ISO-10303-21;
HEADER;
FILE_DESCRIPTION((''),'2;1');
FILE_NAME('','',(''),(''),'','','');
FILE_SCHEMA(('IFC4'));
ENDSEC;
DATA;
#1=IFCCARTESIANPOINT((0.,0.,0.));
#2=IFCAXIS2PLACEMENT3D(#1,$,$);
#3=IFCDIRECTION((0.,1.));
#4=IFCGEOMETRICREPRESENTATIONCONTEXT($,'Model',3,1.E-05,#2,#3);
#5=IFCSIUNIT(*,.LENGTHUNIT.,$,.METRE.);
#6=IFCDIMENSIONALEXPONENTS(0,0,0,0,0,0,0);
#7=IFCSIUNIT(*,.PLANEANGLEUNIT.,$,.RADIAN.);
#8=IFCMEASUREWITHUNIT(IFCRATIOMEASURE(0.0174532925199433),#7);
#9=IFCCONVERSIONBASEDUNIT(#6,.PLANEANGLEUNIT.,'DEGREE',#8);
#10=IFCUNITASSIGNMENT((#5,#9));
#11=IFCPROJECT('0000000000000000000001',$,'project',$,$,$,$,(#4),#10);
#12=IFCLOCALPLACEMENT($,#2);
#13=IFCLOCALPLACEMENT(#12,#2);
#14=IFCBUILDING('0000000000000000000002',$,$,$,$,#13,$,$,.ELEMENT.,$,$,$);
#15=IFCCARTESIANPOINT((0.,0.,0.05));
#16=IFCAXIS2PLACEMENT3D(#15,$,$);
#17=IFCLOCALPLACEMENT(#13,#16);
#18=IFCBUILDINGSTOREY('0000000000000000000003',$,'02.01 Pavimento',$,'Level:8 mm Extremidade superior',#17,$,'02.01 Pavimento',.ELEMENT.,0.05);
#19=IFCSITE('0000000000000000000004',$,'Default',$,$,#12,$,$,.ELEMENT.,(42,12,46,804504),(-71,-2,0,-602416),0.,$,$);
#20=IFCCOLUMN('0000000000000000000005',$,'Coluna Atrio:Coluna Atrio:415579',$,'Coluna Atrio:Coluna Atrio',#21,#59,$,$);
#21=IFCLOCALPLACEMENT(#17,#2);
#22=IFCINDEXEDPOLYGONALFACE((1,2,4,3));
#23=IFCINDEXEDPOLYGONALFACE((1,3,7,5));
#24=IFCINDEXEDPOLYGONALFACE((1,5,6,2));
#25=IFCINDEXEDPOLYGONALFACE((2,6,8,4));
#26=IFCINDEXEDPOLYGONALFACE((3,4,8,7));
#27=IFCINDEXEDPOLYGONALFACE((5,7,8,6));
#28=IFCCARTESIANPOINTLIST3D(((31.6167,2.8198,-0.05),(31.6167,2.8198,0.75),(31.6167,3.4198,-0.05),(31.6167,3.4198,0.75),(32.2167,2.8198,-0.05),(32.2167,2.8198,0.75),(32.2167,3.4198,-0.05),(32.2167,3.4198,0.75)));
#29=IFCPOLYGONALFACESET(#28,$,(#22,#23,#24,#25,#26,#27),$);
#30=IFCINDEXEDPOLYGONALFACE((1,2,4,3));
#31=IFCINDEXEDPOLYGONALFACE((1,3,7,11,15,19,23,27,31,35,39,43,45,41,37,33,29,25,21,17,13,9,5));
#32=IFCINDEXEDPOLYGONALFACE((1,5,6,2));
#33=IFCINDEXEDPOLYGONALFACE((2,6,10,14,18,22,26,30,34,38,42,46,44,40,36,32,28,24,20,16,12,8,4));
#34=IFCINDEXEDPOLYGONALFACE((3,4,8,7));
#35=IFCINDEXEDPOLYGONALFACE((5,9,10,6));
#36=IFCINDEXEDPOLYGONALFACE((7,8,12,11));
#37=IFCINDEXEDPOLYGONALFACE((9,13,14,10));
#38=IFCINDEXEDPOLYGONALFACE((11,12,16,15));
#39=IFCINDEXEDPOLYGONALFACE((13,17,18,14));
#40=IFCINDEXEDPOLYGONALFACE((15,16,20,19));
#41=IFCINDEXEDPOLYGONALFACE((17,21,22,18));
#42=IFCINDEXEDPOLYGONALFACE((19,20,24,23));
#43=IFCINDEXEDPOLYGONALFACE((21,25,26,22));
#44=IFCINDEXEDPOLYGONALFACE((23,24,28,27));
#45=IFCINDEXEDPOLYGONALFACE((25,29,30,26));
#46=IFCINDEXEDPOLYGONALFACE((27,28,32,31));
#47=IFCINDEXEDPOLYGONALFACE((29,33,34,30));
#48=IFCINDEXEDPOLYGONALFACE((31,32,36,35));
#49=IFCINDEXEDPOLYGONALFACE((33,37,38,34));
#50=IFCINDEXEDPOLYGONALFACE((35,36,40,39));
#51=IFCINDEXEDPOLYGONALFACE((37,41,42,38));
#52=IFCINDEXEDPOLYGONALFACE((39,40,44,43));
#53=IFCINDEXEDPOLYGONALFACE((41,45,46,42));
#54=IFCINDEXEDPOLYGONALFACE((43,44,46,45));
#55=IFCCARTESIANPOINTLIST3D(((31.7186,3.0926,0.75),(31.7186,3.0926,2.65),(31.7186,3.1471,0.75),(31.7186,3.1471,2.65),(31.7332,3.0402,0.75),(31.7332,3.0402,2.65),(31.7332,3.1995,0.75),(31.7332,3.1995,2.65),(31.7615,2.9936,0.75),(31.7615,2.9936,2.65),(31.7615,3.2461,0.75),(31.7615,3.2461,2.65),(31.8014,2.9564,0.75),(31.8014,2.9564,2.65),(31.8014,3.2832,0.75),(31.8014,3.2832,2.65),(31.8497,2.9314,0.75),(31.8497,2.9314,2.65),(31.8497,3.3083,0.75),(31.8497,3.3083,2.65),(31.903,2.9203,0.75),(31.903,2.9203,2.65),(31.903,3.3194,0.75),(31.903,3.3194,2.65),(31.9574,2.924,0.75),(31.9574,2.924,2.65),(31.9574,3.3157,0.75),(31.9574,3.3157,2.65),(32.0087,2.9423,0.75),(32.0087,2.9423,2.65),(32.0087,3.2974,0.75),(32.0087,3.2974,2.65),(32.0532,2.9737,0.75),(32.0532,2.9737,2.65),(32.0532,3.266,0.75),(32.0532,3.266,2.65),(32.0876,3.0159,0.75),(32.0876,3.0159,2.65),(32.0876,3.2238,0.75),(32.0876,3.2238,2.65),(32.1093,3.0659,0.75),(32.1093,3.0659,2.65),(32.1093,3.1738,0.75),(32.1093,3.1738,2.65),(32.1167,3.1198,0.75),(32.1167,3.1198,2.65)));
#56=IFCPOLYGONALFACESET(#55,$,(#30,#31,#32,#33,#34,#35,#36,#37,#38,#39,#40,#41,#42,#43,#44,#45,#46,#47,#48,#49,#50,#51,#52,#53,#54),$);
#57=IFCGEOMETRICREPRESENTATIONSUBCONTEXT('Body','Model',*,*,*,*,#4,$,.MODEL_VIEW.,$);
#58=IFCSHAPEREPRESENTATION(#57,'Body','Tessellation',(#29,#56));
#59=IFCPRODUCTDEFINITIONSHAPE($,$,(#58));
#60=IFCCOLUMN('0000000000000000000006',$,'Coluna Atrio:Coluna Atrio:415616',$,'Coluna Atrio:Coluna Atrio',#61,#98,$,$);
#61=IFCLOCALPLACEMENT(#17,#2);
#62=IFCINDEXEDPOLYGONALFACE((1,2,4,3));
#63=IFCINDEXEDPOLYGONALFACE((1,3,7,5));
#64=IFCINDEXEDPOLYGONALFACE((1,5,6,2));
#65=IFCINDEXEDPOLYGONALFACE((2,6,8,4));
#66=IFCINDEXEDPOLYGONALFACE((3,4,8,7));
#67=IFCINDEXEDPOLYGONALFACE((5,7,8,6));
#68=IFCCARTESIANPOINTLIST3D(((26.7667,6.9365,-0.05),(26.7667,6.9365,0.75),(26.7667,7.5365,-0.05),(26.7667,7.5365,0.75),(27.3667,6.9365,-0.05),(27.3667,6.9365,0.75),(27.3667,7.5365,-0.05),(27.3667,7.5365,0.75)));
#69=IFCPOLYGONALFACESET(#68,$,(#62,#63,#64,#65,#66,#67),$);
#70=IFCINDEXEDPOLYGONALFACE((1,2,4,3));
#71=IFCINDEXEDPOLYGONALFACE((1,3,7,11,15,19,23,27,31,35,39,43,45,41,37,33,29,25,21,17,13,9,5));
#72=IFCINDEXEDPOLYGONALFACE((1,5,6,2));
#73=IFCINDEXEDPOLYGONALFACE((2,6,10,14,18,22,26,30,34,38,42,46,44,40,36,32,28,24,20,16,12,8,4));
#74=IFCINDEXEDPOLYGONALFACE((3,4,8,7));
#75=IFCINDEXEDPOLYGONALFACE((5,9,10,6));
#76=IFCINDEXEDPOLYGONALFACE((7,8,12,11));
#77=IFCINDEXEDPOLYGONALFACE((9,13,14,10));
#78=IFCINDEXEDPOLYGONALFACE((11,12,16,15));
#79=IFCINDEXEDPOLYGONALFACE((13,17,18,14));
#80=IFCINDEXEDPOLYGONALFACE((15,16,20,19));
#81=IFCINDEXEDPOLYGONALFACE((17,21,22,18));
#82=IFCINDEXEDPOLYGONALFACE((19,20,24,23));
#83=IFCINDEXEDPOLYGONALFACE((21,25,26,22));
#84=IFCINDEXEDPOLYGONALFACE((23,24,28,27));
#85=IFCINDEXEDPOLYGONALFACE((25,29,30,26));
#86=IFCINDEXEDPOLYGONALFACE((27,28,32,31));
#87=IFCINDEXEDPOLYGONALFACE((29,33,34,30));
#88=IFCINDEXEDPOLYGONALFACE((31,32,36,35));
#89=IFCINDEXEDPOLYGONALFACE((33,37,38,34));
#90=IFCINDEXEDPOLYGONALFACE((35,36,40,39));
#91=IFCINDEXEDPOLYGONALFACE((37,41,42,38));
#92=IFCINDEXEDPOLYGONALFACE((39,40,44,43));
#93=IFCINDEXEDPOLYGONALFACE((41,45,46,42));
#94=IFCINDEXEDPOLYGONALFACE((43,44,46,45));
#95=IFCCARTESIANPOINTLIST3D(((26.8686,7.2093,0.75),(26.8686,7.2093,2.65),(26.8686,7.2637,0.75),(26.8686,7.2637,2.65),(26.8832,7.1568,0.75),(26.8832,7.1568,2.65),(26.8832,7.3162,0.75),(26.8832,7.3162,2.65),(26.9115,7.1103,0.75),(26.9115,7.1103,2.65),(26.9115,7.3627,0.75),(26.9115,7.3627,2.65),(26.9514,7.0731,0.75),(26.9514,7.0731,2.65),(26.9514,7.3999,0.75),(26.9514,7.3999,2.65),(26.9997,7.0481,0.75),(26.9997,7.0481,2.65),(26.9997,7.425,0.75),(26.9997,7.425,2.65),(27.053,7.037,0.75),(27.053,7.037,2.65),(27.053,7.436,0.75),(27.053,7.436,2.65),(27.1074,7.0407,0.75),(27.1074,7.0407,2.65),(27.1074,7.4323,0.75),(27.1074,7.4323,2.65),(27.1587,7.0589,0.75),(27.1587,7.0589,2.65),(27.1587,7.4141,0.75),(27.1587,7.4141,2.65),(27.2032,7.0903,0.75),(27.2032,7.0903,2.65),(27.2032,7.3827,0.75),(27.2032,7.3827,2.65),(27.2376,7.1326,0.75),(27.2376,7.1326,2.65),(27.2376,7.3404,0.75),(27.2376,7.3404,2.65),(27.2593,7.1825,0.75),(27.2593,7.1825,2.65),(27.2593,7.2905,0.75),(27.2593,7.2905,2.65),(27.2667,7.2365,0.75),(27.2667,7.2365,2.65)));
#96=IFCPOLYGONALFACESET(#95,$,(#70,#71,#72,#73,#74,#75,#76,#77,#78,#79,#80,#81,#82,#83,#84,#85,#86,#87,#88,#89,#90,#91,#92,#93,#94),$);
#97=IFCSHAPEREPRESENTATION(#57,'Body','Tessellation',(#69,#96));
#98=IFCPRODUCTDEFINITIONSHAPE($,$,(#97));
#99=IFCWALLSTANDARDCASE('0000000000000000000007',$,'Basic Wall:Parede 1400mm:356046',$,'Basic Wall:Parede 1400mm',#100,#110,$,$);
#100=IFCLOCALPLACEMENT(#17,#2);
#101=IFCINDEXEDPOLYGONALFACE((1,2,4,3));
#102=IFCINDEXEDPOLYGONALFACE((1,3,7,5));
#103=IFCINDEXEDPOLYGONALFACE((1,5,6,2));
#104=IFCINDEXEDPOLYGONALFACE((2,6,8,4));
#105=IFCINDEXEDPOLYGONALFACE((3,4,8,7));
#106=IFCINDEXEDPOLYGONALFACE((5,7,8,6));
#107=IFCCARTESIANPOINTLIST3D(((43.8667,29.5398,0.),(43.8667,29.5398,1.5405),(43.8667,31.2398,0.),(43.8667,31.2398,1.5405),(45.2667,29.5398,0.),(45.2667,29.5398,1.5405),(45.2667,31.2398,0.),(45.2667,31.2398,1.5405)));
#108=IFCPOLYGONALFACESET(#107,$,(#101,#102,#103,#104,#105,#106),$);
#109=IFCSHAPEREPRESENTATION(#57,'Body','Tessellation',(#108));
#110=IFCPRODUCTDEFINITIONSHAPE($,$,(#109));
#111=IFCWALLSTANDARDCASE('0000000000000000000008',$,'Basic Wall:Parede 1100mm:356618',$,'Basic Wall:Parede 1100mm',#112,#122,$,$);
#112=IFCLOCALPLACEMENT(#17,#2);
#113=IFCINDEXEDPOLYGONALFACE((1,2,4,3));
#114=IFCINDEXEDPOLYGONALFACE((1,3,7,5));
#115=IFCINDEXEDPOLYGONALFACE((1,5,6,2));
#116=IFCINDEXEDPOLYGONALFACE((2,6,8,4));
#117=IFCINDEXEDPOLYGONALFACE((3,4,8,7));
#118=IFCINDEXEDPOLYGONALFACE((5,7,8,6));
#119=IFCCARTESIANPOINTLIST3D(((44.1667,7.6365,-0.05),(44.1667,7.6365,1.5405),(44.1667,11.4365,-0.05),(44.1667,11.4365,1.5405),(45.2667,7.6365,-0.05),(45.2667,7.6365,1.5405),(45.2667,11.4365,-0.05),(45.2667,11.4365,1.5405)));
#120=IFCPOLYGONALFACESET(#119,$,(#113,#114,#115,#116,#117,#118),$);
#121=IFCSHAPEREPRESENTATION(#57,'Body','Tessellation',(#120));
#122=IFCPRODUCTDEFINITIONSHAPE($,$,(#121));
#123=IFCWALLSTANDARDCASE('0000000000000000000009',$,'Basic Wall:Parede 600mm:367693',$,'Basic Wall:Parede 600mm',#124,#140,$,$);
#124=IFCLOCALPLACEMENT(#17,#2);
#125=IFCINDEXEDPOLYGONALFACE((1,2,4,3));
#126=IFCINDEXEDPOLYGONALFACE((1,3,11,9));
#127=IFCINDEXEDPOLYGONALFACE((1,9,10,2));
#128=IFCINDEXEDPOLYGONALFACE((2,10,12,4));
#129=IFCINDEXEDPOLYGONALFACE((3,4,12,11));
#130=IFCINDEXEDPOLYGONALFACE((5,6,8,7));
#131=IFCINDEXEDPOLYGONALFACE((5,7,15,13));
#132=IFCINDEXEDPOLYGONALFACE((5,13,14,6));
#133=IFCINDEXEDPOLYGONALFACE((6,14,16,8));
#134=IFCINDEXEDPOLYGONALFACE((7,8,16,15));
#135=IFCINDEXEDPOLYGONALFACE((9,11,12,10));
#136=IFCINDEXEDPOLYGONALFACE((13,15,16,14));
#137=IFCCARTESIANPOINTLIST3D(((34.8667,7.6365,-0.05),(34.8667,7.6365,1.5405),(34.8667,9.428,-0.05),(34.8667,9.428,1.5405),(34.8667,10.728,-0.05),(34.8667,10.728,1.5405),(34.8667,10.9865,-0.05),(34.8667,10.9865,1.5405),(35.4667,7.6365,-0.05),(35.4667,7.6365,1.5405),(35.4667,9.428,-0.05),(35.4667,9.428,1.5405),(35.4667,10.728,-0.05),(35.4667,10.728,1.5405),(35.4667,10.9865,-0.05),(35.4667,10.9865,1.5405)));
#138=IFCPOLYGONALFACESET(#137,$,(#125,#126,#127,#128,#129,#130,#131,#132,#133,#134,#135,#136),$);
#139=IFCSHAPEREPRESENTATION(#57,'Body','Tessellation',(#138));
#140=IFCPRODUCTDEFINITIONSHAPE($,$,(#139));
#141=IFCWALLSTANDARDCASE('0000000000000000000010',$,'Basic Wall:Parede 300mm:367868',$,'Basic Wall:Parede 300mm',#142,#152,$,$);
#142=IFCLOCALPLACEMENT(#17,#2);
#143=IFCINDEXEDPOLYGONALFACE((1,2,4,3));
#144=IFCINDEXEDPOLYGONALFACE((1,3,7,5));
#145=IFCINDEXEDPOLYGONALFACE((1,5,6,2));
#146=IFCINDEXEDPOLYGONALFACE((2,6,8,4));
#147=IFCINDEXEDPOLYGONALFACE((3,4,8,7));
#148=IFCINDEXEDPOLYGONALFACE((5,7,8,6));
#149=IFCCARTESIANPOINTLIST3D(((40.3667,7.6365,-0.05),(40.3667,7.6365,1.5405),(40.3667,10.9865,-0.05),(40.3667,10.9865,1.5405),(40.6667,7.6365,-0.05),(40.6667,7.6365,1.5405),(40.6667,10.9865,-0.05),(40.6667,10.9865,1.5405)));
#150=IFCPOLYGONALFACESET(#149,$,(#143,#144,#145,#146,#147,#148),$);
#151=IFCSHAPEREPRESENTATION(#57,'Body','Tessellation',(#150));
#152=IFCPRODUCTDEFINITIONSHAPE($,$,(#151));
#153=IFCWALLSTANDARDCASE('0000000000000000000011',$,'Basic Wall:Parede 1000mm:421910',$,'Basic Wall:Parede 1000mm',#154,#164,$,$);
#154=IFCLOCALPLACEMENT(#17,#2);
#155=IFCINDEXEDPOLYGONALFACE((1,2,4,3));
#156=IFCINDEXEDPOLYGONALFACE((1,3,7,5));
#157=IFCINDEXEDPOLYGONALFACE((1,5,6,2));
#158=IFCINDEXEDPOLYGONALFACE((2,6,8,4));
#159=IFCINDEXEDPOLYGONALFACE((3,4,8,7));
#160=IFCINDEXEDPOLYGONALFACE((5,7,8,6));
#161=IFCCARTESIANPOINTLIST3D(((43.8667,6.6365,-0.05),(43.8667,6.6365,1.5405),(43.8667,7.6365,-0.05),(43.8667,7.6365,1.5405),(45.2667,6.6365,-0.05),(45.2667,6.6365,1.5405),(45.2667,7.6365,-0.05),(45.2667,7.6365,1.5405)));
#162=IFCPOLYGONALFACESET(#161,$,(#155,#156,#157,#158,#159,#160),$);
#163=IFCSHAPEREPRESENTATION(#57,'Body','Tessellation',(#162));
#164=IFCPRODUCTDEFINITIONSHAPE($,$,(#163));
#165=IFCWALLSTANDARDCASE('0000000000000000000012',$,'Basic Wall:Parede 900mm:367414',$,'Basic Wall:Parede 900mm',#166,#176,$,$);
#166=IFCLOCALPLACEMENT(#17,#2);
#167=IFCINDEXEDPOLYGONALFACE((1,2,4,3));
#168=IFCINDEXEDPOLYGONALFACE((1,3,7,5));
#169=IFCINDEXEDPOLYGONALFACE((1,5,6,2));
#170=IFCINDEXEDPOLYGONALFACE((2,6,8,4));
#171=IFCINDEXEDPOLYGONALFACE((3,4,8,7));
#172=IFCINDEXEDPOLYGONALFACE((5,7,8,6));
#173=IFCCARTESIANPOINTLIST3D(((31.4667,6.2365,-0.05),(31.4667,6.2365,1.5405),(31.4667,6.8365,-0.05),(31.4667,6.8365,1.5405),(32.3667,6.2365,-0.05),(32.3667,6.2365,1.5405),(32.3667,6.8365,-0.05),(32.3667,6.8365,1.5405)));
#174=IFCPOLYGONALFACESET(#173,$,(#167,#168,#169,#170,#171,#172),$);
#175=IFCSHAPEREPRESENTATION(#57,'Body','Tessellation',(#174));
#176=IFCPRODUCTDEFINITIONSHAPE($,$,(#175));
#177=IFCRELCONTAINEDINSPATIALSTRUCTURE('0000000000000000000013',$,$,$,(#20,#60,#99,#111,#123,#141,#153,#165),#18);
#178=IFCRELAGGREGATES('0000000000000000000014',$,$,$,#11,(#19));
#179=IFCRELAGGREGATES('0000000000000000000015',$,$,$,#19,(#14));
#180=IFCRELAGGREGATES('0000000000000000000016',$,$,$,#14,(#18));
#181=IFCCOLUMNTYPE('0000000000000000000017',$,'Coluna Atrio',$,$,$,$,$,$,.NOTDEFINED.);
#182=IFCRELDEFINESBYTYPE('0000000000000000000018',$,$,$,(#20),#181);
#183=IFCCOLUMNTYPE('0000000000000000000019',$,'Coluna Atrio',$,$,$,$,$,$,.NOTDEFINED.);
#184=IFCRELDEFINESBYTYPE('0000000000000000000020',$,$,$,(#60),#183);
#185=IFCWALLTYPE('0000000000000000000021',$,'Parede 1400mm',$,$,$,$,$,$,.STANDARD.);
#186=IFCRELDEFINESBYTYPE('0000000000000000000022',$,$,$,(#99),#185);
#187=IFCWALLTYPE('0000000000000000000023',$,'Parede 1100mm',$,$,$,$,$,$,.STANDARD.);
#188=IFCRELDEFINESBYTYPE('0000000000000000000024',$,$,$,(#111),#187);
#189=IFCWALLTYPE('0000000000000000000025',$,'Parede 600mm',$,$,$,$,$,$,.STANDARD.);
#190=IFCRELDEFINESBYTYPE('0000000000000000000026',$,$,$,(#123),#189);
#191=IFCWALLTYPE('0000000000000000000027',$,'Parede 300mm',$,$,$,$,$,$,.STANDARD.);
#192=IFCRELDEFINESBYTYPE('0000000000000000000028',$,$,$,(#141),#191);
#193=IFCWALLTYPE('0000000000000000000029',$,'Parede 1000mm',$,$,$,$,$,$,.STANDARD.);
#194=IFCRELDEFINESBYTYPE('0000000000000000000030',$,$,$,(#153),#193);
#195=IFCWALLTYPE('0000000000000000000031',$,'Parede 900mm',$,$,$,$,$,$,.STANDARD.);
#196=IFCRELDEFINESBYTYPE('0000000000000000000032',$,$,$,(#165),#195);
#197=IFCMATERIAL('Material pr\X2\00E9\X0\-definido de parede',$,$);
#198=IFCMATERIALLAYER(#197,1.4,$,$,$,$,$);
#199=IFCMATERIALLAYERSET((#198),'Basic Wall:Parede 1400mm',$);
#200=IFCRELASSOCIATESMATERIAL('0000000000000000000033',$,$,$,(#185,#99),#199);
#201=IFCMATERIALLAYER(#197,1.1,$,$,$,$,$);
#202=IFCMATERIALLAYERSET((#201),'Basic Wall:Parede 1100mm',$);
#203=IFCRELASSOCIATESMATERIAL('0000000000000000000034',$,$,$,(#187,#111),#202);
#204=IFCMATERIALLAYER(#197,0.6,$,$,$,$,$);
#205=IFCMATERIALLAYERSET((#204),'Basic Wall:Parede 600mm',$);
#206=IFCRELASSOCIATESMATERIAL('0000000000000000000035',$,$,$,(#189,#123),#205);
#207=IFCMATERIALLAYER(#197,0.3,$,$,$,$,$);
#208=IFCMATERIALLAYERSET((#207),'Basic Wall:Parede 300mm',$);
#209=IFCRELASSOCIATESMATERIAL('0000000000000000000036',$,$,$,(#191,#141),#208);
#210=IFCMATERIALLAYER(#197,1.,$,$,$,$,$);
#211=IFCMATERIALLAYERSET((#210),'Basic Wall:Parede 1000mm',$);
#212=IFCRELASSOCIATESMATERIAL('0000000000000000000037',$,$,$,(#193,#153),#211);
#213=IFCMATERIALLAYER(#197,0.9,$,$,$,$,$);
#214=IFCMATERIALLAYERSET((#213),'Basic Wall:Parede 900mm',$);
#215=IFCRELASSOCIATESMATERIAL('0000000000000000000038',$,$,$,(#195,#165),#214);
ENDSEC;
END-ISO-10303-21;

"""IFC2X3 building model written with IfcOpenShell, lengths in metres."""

from ifc_helpers import new_model, entity, si_unit, converted_unit, direction, frame, frame_2d, origin, origin_2d_with_axis, place, context, subcontext, project, spatial, rectangle, circle, extrude, clip, halfspace, source, transform, mapped, material, layer, layer_set, layer_usage, type_object, type_shapes, element, save


model = new_model("IFC2X3")

# Units and contexts
model_context = context("Model", 3, precision=1e-05, world=origin(), true_north=direction((0.0, 1.0)))
body_context = subcontext(model_context, "Body", "Model", "MODEL_VIEW")
ifc_project = project(units=[si_unit("LENGTHUNIT", "METRE"), converted_unit("PLANEANGLEUNIT", "DEGREE", entity("IfcRatioMeasure", 0.0174532925199433), si_unit("PLANEANGLEUNIT", "RADIAN"), dimensions=[0, 0, 0, 0, 0, 0, 0])], contexts=[model_context])

# Site, building, storey
site_placement = place(None, origin())
site = spatial("IfcSite", under=ifc_project, at=site_placement, Name="Default", CompositionType="ELEMENT", RefLatitude=(42, 12, 46, 804504), RefLongitude=(-71, -2, 0, -602416), RefElevation=0.0)
building_placement = place(site_placement, origin())
building = spatial("IfcBuilding", under=site, at=building_placement, CompositionType="ELEMENT")
storey_placement = place(building_placement, frame((0.0, 0.0, 0.05)))
storey = spatial("IfcBuildingStorey", under=building, at=storey_placement, Name="02.01 Pavimento", ObjectType="Level:8 mm Extremidade superior", LongName="02.01 Pavimento", CompositionType="ELEMENT", Elevation=0.05)

# Columns
column_type_1 = type_object("IfcColumnType", Name="Coluna Atrio", PredefinedType="NOTDEFINED")
shared_shape_1 = source(origin(), body_context, "Body", "SweptSolid", [
    extrude(rectangle(XDim=0.6, YDim=0.6, at=origin_2d_with_axis()), frame((0.0, 0.0, 0.0), z_axis=(0.0, 0.0, 1.0), x_axis=(0.0, -1.0, 0.0)), (0.0, 0.0, 1.0), 0.8),
    extrude(circle(Radius=0.2, at=frame_2d((0.0, 0.0), x_axis=(1.0, 0.0))), frame((0.0, 0.0, 0.8)), (0.0, 0.0, 1.0), 1.9),
])
type_shapes(column_type_1, [shared_shape_1])
column_1_placement = place(storey_placement, frame((31.9167, 3.1198, -0.05)))
element("IfcColumn", 1, at=column_1_placement, inside=storey, type_object=column_type_1, Name="Coluna Atrio:Coluna Atrio:415579", ObjectType="Coluna Atrio:Coluna Atrio", context=body_context, shape_type="MappedRepresentation", body=[
    mapped(shared_shape_1, transform((0.0, 0.0, 0.0), scale=1.0)),
])
column_type_2 = type_object("IfcColumnType", Name="Coluna Atrio", PredefinedType="NOTDEFINED")
shared_shape_2 = source(origin(), body_context, "Body", "SweptSolid", [
    extrude(rectangle(XDim=0.6, YDim=0.6, at=origin_2d_with_axis()), frame((0.0, 0.0, 0.0), z_axis=(0.0, 0.0, 1.0), x_axis=(0.0, -1.0, 0.0)), (0.0, 0.0, 1.0), 0.8),
    extrude(circle(Radius=0.2, at=frame_2d((0.0, 0.0), x_axis=(1.0, 0.0))), frame((0.0, 0.0, 0.8)), (0.0, 0.0, 1.0), 1.9),
])
type_shapes(column_type_2, [shared_shape_2])
column_2_placement = place(storey_placement, frame((27.0667, 7.2365, -0.05)))
element("IfcColumn", 2, at=column_2_placement, inside=storey, type_object=column_type_2, Name="Coluna Atrio:Coluna Atrio:415616", ObjectType="Coluna Atrio:Coluna Atrio", context=body_context, shape_type="MappedRepresentation", body=[
    mapped(shared_shape_2, transform((0.0, 0.0, 0.0), scale=1.0)),
])

# Walls
ifc_material = material(Name="Material pré-definido de parede")
ifc_layer_1 = layer(ifc_material, 1.4)
ifc_layer_set_1 = layer_set([ifc_layer_1], Name="Basic Wall:Parede 1400mm")
ifc_layer_usage_1 = layer_usage(ifc_layer_set_1, "AXIS2", "POSITIVE", -0.7)
wall_type_1 = type_object("IfcWallType", Name="Parede 1400mm", PredefinedType="STANDARD", material=ifc_layer_set_1)
wall_1_placement = place(storey_placement, frame((44.5667, 31.2398, 0.0), z_axis=(0.0, 0.0, 1.0), x_axis=(0.0, -1.0, 0.0)))
element("IfcWallStandardCase", 3, at=wall_1_placement, inside=storey, type_object=wall_type_1, material=ifc_layer_usage_1, Name="Basic Wall:Parede 1400mm:356046", ObjectType="Basic Wall:Parede 1400mm", context=body_context, shape_type="Clipping", body=[
    clip(extrude(rectangle(XDim=1.7, YDim=1.4, at=frame_2d((0.85, 0.0), x_axis=(-1.0, 0.0))), origin(), (0.0, 0.0, 1.0), 1.5405), halfspace(frame((0.0, 0.0, -2.9)), True)),
])
ifc_layer_2 = layer(ifc_material, 1.1)
ifc_layer_set_2 = layer_set([ifc_layer_2], Name="Basic Wall:Parede 1100mm")
ifc_layer_usage_2 = layer_usage(ifc_layer_set_2, "AXIS2", "NEGATIVE", 0.55)
wall_type_2 = type_object("IfcWallType", Name="Parede 1100mm", PredefinedType="STANDARD", material=ifc_layer_set_2)
wall_2_placement = place(storey_placement, frame((44.7167, 11.4365, -0.05), z_axis=(0.0, 0.0, 1.0), x_axis=(0.0, -1.0, 0.0)))
element("IfcWallStandardCase", 4, at=wall_2_placement, inside=storey, type_object=wall_type_2, material=ifc_layer_usage_2, Name="Basic Wall:Parede 1100mm:356618", ObjectType="Basic Wall:Parede 1100mm", context=body_context, shape_type="Clipping", body=[
    clip(extrude(rectangle(XDim=3.8, YDim=1.1, at=frame_2d((1.9, 0.0), x_axis=(-1.0, 0.0))), origin(), (0.0, 0.0, 1.0), 1.5905), halfspace(frame((0.0, 0.0, -0.05)), True)),
])

# Shared definitions
ifc_layer_3 = layer(ifc_material, 0.6)
ifc_layer_set_3 = layer_set([ifc_layer_3], Name="Basic Wall:Parede 600mm")
wall_type_3 = type_object("IfcWallType", Name="Parede 600mm", PredefinedType="STANDARD", material=ifc_layer_set_3)

# Wall, opening
ifc_layer_usage_3 = layer_usage(ifc_layer_set_3, "AXIS2", "NEGATIVE", 0.3)
wall_3_placement = place(storey_placement, frame((35.1667, 10.9865, -0.05), z_axis=(0.0, 0.0, 1.0), x_axis=(0.0, -1.0, 0.0)))
wall_3 = element("IfcWallStandardCase", 5, at=wall_3_placement, inside=storey, type_object=wall_type_3, material=ifc_layer_usage_3, Name="Basic Wall:Parede 600mm:367693", ObjectType="Basic Wall:Parede 600mm", context=body_context, shape_type="Clipping", body=[
    clip(extrude(rectangle(XDim=0.6, YDim=3.35, at=frame_2d((1.675, 0.0), x_axis=(0.0, 1.0))), origin(), (0.0, 0.0, 1.0), 1.5905), halfspace(frame((0.0, 0.0, -0.05)), True)),
])
opening_1_placement = place(wall_3_placement, frame((1.5585, -1.824, 0.0), z_axis=(0.0, 0.0, 1.0), x_axis=(0.0, 1.0, 0.0)))
element("IfcOpeningElement", 6, at=opening_1_placement, cuts=wall_3, ObjectType="Opening", context=body_context, shape_type="SweptSolid", body=[
    extrude(rectangle(XDim=3.4, YDim=1.3, at=frame_2d((0.0, 0.0), x_axis=(1.0, 0.0))), frame((0.0, 0.65, 1.7), z_axis=(1.0, 0.0, 0.0), x_axis=(0.0, 0.0, 1.0)), (0.0, 0.0, 1.0), 3.048),
])

# Wall
ifc_layer_4 = layer(ifc_material, 0.3)
ifc_layer_set_4 = layer_set([ifc_layer_4], Name="Basic Wall:Parede 300mm")
ifc_layer_usage_4 = layer_usage(ifc_layer_set_4, "AXIS2", "NEGATIVE", 0.15)
wall_type_4 = type_object("IfcWallType", Name="Parede 300mm", PredefinedType="STANDARD", material=ifc_layer_set_4)
wall_4_placement = place(storey_placement, frame((40.5167, 7.6365, -0.05), z_axis=(0.0, 0.0, 1.0), x_axis=(0.0, 1.0, 0.0)))
element("IfcWallStandardCase", 7, at=wall_4_placement, inside=storey, type_object=wall_type_4, material=ifc_layer_usage_4, Name="Basic Wall:Parede 300mm:367868", ObjectType="Basic Wall:Parede 300mm", context=body_context, shape_type="Clipping", body=[
    clip(extrude(rectangle(XDim=0.3, YDim=3.35, at=frame_2d((1.675, 0.0), x_axis=(0.0, 1.0))), origin(), (0.0, 0.0, 1.0), 1.5905), halfspace(frame((0.0, 0.0, -0.05)), True)),
])

# Shared definitions
ifc_layer_5 = layer(ifc_material, 1.0)
ifc_layer_set_5 = layer_set([ifc_layer_5], Name="Basic Wall:Parede 1000mm")
wall_type_5 = type_object("IfcWallType", Name="Parede 1000mm", PredefinedType="STANDARD", material=ifc_layer_set_5)

# Walls
ifc_layer_usage_5 = layer_usage(ifc_layer_set_5, "AXIS2", "NEGATIVE", 0.5)
wall_5_placement = place(storey_placement, frame((43.8667, 7.1365, -0.05)))
element("IfcWallStandardCase", 8, at=wall_5_placement, inside=storey, type_object=wall_type_5, material=ifc_layer_usage_5, Name="Basic Wall:Parede 1000mm:421910", ObjectType="Basic Wall:Parede 1000mm", context=body_context, shape_type="Clipping", body=[
    clip(extrude(rectangle(XDim=1.4, YDim=1.0, at=frame_2d((0.7, 0.0), x_axis=(-1.0, 0.0))), origin(), (0.0, 0.0, 1.0), 1.5905), halfspace(frame((0.0, 0.0, -0.05)), True)),
])
ifc_layer_6 = layer(ifc_material, 0.9)
ifc_layer_set_6 = layer_set([ifc_layer_6], Name="Basic Wall:Parede 900mm")
ifc_layer_usage_6 = layer_usage(ifc_layer_set_6, "AXIS2", "NEGATIVE", 0.45)
wall_type_6 = type_object("IfcWallType", Name="Parede 900mm", PredefinedType="STANDARD", material=ifc_layer_set_6)
wall_6_placement = place(storey_placement, frame((31.9167, 6.2365, -0.05), z_axis=(0.0, 0.0, 1.0), x_axis=(0.0, 1.0, 0.0)))
element("IfcWallStandardCase", 9, at=wall_6_placement, inside=storey, type_object=wall_type_6, material=ifc_layer_usage_6, Name="Basic Wall:Parede 900mm:367414", ObjectType="Basic Wall:Parede 900mm", context=body_context, shape_type="Clipping", body=[
    clip(extrude(rectangle(XDim=0.6, YDim=0.9, at=frame_2d((0.3, 0.0), x_axis=(-1.0, 0.0))), origin(), (0.0, 0.0, 1.0), 1.5905), halfspace(frame((0.0, 0.0, -0.05)), True)),
])

save(model, "model.ifc")
